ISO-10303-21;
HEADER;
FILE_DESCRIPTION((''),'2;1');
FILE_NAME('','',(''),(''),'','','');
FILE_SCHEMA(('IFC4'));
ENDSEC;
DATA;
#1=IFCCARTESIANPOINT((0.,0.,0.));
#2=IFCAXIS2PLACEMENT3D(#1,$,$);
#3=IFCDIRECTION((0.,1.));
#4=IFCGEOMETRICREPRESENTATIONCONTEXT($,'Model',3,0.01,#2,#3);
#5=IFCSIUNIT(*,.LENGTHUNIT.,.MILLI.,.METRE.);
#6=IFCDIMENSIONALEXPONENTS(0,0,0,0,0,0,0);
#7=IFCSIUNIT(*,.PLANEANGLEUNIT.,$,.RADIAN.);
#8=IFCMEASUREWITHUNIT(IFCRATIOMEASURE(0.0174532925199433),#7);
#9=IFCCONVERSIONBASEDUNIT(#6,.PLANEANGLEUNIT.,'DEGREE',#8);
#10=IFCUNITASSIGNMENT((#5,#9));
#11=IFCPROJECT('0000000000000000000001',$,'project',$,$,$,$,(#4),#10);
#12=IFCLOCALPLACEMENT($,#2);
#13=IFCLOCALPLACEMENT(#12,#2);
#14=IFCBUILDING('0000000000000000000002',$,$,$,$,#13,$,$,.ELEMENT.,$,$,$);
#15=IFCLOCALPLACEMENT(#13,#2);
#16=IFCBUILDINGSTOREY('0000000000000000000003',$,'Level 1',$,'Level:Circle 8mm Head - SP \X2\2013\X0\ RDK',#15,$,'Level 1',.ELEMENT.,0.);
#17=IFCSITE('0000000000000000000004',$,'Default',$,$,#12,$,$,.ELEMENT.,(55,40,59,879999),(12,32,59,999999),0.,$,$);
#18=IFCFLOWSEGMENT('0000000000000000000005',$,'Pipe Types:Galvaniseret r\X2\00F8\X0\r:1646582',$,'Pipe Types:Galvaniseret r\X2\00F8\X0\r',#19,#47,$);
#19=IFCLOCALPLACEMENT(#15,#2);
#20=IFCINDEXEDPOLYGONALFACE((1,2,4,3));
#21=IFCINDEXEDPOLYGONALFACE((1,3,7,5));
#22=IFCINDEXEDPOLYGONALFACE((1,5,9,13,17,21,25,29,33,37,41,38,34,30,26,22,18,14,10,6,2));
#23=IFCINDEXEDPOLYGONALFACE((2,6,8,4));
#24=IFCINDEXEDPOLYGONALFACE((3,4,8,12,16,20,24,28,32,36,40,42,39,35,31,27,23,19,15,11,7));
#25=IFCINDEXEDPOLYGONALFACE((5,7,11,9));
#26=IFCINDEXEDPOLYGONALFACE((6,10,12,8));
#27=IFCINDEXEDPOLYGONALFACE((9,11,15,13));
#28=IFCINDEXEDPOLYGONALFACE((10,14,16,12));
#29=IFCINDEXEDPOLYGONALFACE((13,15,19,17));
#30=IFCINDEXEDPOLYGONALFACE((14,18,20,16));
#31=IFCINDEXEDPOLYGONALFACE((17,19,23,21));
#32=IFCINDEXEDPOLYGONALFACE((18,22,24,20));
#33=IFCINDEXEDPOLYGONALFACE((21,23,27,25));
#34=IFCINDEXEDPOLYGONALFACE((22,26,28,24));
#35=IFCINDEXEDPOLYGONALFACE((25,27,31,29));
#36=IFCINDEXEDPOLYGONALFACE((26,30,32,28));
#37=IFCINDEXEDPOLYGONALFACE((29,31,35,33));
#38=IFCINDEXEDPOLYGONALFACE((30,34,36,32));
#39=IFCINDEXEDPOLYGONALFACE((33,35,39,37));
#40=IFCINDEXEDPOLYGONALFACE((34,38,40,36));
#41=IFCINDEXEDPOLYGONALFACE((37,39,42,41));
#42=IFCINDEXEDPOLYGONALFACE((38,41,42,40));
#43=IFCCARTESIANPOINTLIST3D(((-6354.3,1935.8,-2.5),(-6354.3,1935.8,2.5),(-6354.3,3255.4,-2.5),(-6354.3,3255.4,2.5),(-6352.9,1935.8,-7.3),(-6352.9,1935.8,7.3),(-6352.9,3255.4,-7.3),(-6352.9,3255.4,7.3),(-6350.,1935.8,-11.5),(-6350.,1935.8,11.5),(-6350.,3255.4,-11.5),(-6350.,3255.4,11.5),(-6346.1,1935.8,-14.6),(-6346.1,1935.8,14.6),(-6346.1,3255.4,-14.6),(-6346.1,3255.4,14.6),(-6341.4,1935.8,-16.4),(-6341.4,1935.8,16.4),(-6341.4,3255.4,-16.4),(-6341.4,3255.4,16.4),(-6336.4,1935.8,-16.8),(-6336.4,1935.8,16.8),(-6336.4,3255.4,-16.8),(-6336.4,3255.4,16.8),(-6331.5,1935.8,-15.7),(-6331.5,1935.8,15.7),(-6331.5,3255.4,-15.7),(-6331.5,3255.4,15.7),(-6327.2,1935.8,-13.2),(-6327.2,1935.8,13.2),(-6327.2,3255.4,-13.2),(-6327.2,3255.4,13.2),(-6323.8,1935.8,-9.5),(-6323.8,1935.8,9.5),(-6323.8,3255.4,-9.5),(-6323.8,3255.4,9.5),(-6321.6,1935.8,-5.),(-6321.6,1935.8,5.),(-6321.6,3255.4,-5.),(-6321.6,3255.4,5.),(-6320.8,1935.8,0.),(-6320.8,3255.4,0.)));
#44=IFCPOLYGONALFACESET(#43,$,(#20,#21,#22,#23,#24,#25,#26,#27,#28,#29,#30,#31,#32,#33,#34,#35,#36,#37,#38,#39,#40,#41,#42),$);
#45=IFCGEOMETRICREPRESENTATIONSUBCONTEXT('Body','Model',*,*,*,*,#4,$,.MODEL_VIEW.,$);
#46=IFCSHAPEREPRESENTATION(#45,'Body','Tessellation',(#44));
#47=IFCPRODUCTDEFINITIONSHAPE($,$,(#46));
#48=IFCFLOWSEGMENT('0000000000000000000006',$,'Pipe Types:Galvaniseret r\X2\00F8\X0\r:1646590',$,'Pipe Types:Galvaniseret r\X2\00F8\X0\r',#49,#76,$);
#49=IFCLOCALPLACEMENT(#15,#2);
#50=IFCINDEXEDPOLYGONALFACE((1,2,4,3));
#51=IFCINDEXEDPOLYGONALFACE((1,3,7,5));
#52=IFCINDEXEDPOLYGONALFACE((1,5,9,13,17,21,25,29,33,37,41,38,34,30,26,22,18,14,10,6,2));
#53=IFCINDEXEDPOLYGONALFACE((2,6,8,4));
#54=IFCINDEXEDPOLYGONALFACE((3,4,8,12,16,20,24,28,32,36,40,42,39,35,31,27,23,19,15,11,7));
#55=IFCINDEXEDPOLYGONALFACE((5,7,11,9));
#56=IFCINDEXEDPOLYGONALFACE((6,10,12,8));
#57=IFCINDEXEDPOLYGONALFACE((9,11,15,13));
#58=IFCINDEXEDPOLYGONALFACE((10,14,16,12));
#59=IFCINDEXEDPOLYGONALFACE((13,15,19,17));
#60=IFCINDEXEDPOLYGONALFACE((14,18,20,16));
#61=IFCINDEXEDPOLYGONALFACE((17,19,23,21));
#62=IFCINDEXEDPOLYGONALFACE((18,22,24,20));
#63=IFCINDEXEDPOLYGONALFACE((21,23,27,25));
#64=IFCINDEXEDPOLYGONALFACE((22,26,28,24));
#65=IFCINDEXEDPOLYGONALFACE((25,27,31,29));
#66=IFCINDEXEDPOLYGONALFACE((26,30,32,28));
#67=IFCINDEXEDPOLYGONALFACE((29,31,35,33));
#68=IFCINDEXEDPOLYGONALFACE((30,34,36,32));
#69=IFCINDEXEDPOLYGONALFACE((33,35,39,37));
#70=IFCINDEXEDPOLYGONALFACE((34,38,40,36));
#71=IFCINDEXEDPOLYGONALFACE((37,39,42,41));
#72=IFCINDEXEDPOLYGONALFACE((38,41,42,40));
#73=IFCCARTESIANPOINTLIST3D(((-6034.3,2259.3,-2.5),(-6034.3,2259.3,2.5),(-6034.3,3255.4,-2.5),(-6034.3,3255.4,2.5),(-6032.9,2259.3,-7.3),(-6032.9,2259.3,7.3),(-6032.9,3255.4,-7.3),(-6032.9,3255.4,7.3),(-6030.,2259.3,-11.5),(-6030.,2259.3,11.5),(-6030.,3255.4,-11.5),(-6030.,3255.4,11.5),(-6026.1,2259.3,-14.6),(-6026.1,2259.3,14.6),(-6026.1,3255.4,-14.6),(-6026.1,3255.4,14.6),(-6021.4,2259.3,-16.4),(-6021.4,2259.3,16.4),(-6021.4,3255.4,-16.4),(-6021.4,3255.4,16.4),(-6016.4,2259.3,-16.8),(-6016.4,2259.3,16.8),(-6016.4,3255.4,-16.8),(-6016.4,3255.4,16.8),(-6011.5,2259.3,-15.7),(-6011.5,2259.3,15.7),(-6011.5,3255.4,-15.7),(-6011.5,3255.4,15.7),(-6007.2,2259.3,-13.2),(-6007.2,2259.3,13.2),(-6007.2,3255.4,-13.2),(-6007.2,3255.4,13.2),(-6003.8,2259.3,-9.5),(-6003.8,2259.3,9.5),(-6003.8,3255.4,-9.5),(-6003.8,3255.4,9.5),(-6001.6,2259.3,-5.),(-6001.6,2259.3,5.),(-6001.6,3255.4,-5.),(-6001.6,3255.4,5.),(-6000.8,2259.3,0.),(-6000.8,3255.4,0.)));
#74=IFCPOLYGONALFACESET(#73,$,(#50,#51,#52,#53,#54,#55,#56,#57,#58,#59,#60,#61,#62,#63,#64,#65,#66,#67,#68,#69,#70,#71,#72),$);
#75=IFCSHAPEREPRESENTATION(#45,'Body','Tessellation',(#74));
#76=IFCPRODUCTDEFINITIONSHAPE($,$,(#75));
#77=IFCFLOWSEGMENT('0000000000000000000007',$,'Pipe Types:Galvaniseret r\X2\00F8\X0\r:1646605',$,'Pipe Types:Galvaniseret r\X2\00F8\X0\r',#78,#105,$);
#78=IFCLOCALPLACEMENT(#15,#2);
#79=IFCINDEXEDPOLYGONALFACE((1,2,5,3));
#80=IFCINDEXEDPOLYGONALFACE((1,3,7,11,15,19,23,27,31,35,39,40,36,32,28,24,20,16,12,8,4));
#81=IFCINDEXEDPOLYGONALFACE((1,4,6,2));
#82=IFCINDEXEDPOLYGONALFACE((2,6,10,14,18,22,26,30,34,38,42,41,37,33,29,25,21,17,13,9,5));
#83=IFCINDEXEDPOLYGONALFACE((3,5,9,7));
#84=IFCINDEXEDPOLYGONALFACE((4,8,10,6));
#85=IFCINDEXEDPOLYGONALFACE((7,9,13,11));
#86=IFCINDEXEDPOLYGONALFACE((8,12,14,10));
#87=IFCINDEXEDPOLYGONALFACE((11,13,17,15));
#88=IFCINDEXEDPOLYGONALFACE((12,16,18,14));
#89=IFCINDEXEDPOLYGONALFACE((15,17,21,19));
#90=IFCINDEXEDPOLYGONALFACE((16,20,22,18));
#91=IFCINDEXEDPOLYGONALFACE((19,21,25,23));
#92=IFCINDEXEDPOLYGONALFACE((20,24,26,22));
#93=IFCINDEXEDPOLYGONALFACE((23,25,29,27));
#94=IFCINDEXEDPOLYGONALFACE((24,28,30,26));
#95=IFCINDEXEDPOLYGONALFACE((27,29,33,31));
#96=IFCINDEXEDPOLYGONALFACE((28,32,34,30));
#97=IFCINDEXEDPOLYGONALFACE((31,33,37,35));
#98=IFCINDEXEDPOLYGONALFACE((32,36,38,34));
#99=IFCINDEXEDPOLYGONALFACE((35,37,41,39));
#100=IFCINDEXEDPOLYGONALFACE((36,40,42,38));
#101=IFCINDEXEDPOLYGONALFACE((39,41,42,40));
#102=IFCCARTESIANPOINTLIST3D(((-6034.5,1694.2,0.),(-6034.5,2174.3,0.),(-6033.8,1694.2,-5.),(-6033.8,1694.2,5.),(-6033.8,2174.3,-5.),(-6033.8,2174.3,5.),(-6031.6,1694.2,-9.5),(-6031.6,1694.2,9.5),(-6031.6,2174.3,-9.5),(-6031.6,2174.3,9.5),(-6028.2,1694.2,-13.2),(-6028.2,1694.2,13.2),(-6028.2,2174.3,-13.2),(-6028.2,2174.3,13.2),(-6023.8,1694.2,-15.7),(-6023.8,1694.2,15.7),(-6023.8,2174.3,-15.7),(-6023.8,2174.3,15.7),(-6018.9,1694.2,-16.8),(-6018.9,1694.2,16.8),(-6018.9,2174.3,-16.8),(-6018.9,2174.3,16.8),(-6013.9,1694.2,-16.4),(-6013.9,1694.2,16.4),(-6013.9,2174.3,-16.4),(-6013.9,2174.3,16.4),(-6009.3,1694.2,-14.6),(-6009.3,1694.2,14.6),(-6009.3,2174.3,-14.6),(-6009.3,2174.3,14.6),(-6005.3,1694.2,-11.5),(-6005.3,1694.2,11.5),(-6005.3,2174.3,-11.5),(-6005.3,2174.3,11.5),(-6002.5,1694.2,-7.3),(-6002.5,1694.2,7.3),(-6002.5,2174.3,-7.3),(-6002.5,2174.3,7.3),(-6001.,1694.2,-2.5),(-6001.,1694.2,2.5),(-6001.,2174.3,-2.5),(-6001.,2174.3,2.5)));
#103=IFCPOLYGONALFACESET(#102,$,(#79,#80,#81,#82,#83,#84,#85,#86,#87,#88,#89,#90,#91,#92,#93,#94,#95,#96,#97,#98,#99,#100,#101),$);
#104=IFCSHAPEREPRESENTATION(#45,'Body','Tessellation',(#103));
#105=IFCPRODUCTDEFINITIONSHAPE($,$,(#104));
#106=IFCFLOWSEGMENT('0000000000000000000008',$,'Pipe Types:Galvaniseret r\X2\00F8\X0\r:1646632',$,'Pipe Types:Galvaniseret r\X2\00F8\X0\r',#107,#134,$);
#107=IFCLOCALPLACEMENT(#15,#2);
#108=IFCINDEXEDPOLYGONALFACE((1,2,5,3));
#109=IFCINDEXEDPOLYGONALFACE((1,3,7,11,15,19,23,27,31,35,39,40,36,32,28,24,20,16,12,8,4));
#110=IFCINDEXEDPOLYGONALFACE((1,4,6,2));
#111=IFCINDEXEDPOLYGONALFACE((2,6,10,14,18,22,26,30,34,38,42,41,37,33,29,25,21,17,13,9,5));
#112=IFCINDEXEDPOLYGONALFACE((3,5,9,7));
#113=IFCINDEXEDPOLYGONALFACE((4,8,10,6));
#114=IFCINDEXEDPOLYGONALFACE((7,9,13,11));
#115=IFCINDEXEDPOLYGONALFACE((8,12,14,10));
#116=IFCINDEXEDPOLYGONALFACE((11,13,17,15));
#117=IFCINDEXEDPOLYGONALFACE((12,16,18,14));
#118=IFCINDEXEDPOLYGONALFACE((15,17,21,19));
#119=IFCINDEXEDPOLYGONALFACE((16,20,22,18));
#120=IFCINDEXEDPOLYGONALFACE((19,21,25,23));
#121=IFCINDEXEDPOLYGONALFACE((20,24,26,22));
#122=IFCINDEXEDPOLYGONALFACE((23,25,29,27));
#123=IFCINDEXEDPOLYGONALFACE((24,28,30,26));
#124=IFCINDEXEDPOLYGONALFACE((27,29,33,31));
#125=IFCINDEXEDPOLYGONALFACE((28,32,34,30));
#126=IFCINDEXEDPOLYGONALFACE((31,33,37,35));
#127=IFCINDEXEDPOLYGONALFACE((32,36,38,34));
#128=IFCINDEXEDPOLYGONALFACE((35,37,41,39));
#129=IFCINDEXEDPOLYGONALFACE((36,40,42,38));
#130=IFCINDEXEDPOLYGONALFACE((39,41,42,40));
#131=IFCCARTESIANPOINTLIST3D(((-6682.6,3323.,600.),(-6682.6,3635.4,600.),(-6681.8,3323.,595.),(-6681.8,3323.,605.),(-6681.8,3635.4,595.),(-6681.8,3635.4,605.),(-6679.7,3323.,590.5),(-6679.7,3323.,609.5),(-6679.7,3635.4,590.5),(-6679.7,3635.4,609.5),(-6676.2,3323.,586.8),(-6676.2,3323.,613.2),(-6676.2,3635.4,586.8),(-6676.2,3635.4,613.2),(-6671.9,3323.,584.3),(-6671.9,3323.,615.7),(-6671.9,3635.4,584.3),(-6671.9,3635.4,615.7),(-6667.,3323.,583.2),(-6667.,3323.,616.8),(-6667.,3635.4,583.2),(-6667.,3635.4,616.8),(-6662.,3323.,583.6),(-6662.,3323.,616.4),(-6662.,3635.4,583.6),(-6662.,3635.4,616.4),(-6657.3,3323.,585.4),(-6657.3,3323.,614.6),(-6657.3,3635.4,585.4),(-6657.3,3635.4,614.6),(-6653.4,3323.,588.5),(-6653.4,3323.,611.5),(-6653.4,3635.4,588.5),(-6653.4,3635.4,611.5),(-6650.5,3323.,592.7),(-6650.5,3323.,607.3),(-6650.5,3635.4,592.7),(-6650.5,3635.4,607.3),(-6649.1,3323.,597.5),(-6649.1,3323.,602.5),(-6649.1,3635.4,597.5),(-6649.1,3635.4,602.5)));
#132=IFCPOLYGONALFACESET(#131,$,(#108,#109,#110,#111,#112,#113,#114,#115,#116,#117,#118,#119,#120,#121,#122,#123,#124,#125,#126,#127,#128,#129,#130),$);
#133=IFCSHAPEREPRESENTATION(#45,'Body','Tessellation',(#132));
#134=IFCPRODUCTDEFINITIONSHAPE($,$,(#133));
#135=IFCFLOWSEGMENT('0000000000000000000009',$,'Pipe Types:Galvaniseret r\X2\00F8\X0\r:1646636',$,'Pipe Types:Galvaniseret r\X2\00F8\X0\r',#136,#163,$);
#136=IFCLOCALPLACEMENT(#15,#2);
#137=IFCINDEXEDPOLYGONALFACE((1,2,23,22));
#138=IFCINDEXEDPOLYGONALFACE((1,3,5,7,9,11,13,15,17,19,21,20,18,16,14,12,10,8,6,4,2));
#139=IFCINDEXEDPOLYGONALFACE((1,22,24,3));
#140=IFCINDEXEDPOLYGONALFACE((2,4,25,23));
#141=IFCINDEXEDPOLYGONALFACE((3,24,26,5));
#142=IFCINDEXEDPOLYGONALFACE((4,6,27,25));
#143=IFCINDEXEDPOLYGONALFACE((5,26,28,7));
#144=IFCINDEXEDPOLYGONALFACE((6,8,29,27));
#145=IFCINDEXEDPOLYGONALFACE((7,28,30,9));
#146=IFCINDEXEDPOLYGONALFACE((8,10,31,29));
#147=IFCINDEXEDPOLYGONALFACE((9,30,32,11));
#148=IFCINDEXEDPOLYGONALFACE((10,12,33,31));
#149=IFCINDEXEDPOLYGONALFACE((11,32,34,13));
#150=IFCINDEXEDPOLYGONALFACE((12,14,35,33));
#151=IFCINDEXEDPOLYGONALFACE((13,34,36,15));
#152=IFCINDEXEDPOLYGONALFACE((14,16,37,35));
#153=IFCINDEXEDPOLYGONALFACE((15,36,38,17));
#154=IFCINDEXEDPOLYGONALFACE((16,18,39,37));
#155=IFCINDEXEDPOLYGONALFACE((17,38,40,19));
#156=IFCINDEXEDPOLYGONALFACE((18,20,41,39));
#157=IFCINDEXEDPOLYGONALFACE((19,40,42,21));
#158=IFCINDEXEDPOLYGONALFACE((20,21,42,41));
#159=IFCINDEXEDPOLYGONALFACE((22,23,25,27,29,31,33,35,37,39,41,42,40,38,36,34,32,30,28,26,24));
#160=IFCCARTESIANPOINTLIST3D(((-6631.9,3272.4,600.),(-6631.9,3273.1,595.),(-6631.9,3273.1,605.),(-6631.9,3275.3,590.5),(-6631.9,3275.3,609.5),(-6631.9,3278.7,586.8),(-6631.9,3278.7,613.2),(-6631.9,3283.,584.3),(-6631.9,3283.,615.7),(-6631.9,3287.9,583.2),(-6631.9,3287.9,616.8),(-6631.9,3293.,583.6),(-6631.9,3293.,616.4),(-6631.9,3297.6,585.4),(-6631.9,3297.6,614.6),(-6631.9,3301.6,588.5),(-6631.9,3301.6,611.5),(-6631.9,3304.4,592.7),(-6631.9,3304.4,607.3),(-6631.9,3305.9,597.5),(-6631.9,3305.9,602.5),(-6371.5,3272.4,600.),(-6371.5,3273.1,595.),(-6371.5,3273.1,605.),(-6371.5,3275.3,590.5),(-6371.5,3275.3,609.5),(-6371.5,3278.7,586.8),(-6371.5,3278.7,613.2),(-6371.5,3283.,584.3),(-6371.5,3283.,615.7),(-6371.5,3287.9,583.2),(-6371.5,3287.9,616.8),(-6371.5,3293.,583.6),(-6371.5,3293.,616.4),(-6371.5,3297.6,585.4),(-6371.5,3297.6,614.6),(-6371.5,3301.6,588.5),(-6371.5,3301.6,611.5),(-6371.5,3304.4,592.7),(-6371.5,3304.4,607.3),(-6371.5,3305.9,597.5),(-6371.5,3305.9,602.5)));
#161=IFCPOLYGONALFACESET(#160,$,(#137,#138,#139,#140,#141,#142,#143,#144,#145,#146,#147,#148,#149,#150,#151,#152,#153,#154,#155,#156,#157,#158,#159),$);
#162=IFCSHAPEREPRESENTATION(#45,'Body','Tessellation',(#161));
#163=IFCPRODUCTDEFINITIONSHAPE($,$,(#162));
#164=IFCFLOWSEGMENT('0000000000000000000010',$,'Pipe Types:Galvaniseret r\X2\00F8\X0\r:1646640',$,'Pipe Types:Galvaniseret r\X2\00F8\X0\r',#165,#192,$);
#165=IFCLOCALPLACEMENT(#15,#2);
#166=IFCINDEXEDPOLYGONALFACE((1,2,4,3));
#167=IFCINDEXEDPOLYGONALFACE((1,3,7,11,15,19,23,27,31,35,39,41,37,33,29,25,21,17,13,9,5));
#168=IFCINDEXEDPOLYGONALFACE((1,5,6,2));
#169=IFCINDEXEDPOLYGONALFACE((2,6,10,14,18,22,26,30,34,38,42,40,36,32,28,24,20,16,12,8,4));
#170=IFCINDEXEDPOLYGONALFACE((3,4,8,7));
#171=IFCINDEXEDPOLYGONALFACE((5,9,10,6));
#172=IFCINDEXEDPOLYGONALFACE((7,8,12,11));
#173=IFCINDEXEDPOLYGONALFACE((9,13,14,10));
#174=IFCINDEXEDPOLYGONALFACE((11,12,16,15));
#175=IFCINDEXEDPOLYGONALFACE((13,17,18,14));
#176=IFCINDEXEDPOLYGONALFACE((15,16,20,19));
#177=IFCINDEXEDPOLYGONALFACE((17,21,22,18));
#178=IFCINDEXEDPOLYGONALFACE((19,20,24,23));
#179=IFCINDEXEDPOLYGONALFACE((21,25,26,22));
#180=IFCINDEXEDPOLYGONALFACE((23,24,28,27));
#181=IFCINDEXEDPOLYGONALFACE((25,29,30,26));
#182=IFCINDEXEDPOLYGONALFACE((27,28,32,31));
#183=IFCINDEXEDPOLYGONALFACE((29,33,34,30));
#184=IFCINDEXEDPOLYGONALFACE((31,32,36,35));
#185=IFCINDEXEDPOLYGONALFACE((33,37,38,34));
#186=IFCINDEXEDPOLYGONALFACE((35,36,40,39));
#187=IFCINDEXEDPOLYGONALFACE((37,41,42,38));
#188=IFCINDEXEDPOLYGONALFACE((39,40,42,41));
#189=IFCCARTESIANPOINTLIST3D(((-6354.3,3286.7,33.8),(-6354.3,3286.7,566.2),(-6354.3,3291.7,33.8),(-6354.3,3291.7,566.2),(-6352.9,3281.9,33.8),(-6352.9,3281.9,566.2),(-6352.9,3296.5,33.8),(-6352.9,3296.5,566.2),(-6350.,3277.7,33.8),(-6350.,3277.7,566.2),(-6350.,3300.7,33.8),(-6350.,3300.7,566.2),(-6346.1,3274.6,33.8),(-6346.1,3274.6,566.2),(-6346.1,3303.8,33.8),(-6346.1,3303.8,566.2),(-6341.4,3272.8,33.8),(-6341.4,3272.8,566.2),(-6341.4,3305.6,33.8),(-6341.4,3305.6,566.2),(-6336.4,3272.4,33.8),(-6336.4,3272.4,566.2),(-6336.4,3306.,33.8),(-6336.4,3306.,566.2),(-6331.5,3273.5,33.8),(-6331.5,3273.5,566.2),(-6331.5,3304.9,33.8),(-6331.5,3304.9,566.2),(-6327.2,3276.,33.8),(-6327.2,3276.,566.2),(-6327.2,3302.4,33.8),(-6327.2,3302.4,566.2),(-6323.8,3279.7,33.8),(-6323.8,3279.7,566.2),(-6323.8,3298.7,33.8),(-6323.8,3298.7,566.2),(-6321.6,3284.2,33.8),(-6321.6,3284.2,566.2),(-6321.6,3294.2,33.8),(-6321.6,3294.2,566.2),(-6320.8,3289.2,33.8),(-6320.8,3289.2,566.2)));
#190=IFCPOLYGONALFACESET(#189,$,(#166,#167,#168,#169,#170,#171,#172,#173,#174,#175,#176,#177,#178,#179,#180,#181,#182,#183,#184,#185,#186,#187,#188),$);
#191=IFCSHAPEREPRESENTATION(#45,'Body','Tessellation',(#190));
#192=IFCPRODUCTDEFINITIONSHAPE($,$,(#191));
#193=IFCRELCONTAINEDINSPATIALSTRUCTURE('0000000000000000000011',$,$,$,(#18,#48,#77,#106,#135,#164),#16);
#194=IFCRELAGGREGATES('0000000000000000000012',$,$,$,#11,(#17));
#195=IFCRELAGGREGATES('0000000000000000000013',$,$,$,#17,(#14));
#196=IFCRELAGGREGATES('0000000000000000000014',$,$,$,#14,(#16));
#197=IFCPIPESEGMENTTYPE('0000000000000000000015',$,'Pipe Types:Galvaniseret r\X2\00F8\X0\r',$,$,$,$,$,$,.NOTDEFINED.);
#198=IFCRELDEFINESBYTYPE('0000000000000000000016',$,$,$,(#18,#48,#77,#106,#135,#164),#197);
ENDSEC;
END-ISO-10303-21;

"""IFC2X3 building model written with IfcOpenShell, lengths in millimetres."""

from ifc_helpers import new_model, entity, si_unit, converted_unit, direction, frame, frame_2d, origin, origin_2d_with_axis, place, context, subcontext, project, spatial, circle, extrude, type_object, element, save


model = new_model("IFC2X3")

# Units and contexts
model_context = context("Model", 3, precision=0.01, world=origin(), true_north=direction((0.0, 1.0)))
body_context = subcontext(model_context, "Body", "Model", "MODEL_VIEW")
ifc_project = project(units=[si_unit("LENGTHUNIT", "METRE", prefix="MILLI"), converted_unit("PLANEANGLEUNIT", "DEGREE", entity("IfcRatioMeasure", 0.0174532925199433), si_unit("PLANEANGLEUNIT", "RADIAN"), dimensions=[0, 0, 0, 0, 0, 0, 0])], contexts=[model_context])

# Site, building, storey
site_placement = place(None, origin())
site = spatial("IfcSite", under=ifc_project, at=site_placement, Name="Default", CompositionType="ELEMENT", RefLatitude=(55, 40, 59, 879999), RefLongitude=(12, 32, 59, 999999), RefElevation=0.0)
building_placement = place(site_placement, origin())
building = spatial("IfcBuilding", under=site, at=building_placement, CompositionType="ELEMENT")
storey_placement = place(building_placement, origin())
storey = spatial("IfcBuildingStorey", under=building, at=storey_placement, Name="Level 1", ObjectType="Level:Circle 8mm Head - SP – RDK", LongName="Level 1", CompositionType="ELEMENT", Elevation=0.0)

# Flow segments
pipe_segment_type = type_object("IfcPipeSegmentType", Name="Pipe Types:Galvaniseret rør", PredefinedType="NOTDEFINED")
flow_segment_1_placement = place(storey_placement, origin())
element("IfcFlowSegment", 1, at=flow_segment_1_placement, inside=storey, type_object=pipe_segment_type, Name="Pipe Types:Galvaniseret rør:1646582", ObjectType="Pipe Types:Galvaniseret rør", context=body_context, shape_type="SweptSolid", body=[
    extrude(circle(Radius=16.9, at=frame_2d((0.0, 0.0), x_axis=(1.0, 0.0))), frame((-6337.7, 1935.8, 0.0), z_axis=(0.0, 1.0, 0.0), x_axis=(1.0, 0.0, 0.0)), (0.0, 0.0, 1.0), 1319.6),
])
flow_segment_2_placement = place(storey_placement, origin())
element("IfcFlowSegment", 2, at=flow_segment_2_placement, inside=storey, type_object=pipe_segment_type, Name="Pipe Types:Galvaniseret rør:1646590", ObjectType="Pipe Types:Galvaniseret rør", context=body_context, shape_type="SweptSolid", body=[
    extrude(circle(Radius=16.9, at=frame_2d((0.0, 0.0), x_axis=(1.0, 0.0))), frame((-6017.7, 2259.3, 0.0), z_axis=(0.0, 1.0, 0.0), x_axis=(1.0, 0.0, 0.0)), (0.0, 0.0, 1.0), 996.1),
])
flow_segment_3_placement = place(storey_placement, origin())
element("IfcFlowSegment", 3, at=flow_segment_3_placement, inside=storey, type_object=pipe_segment_type, Name="Pipe Types:Galvaniseret rør:1646605", ObjectType="Pipe Types:Galvaniseret rør", context=body_context, shape_type="SweptSolid", body=[
    extrude(circle(Radius=16.9, at=frame_2d((0.0, 0.0), x_axis=(1.0, 0.0))), frame((-6017.7, 1694.2, 0.0), z_axis=(0.0, 1.0, 0.0), x_axis=(-1.0, 0.0, 0.0)), (0.0, 0.0, 1.0), 480.1),
])
flow_segment_4_placement = place(storey_placement, origin())
element("IfcFlowSegment", 4, at=flow_segment_4_placement, inside=storey, type_object=pipe_segment_type, Name="Pipe Types:Galvaniseret rør:1646632", ObjectType="Pipe Types:Galvaniseret rør", context=body_context, shape_type="SweptSolid", body=[
    extrude(circle(Radius=16.9, at=frame_2d((0.0, 0.0), x_axis=(1.0, 0.0))), frame((-6665.7, 3323.0, 600.0), z_axis=(0.0, 1.0, 0.0), x_axis=(-1.0, 0.0, 0.0)), (0.0, 0.0, 1.0), 312.4),
])
flow_segment_5_placement = place(storey_placement, origin())
element("IfcFlowSegment", 5, at=flow_segment_5_placement, inside=storey, type_object=pipe_segment_type, Name="Pipe Types:Galvaniseret rør:1646636", ObjectType="Pipe Types:Galvaniseret rør", context=body_context, shape_type="SweptSolid", body=[
    extrude(circle(Radius=16.9, at=origin_2d_with_axis()), frame((-6631.9, 3289.2, 600.0), z_axis=(1.0, 0.0, 0.0), x_axis=(0.0, -1.0, 0.0)), (0.0, 0.0, 1.0), 260.4),
])
flow_segment_6_placement = place(storey_placement, origin())
element("IfcFlowSegment", 6, at=flow_segment_6_placement, inside=storey, type_object=pipe_segment_type, Name="Pipe Types:Galvaniseret rør:1646640", ObjectType="Pipe Types:Galvaniseret rør", context=body_context, shape_type="SweptSolid", body=[
    extrude(circle(Radius=16.9, at=origin_2d_with_axis()), frame((-6337.7, 3289.2, 33.8)), (0.0, 0.0, 1.0), 532.4),
])

save(model, "model.ifc")
